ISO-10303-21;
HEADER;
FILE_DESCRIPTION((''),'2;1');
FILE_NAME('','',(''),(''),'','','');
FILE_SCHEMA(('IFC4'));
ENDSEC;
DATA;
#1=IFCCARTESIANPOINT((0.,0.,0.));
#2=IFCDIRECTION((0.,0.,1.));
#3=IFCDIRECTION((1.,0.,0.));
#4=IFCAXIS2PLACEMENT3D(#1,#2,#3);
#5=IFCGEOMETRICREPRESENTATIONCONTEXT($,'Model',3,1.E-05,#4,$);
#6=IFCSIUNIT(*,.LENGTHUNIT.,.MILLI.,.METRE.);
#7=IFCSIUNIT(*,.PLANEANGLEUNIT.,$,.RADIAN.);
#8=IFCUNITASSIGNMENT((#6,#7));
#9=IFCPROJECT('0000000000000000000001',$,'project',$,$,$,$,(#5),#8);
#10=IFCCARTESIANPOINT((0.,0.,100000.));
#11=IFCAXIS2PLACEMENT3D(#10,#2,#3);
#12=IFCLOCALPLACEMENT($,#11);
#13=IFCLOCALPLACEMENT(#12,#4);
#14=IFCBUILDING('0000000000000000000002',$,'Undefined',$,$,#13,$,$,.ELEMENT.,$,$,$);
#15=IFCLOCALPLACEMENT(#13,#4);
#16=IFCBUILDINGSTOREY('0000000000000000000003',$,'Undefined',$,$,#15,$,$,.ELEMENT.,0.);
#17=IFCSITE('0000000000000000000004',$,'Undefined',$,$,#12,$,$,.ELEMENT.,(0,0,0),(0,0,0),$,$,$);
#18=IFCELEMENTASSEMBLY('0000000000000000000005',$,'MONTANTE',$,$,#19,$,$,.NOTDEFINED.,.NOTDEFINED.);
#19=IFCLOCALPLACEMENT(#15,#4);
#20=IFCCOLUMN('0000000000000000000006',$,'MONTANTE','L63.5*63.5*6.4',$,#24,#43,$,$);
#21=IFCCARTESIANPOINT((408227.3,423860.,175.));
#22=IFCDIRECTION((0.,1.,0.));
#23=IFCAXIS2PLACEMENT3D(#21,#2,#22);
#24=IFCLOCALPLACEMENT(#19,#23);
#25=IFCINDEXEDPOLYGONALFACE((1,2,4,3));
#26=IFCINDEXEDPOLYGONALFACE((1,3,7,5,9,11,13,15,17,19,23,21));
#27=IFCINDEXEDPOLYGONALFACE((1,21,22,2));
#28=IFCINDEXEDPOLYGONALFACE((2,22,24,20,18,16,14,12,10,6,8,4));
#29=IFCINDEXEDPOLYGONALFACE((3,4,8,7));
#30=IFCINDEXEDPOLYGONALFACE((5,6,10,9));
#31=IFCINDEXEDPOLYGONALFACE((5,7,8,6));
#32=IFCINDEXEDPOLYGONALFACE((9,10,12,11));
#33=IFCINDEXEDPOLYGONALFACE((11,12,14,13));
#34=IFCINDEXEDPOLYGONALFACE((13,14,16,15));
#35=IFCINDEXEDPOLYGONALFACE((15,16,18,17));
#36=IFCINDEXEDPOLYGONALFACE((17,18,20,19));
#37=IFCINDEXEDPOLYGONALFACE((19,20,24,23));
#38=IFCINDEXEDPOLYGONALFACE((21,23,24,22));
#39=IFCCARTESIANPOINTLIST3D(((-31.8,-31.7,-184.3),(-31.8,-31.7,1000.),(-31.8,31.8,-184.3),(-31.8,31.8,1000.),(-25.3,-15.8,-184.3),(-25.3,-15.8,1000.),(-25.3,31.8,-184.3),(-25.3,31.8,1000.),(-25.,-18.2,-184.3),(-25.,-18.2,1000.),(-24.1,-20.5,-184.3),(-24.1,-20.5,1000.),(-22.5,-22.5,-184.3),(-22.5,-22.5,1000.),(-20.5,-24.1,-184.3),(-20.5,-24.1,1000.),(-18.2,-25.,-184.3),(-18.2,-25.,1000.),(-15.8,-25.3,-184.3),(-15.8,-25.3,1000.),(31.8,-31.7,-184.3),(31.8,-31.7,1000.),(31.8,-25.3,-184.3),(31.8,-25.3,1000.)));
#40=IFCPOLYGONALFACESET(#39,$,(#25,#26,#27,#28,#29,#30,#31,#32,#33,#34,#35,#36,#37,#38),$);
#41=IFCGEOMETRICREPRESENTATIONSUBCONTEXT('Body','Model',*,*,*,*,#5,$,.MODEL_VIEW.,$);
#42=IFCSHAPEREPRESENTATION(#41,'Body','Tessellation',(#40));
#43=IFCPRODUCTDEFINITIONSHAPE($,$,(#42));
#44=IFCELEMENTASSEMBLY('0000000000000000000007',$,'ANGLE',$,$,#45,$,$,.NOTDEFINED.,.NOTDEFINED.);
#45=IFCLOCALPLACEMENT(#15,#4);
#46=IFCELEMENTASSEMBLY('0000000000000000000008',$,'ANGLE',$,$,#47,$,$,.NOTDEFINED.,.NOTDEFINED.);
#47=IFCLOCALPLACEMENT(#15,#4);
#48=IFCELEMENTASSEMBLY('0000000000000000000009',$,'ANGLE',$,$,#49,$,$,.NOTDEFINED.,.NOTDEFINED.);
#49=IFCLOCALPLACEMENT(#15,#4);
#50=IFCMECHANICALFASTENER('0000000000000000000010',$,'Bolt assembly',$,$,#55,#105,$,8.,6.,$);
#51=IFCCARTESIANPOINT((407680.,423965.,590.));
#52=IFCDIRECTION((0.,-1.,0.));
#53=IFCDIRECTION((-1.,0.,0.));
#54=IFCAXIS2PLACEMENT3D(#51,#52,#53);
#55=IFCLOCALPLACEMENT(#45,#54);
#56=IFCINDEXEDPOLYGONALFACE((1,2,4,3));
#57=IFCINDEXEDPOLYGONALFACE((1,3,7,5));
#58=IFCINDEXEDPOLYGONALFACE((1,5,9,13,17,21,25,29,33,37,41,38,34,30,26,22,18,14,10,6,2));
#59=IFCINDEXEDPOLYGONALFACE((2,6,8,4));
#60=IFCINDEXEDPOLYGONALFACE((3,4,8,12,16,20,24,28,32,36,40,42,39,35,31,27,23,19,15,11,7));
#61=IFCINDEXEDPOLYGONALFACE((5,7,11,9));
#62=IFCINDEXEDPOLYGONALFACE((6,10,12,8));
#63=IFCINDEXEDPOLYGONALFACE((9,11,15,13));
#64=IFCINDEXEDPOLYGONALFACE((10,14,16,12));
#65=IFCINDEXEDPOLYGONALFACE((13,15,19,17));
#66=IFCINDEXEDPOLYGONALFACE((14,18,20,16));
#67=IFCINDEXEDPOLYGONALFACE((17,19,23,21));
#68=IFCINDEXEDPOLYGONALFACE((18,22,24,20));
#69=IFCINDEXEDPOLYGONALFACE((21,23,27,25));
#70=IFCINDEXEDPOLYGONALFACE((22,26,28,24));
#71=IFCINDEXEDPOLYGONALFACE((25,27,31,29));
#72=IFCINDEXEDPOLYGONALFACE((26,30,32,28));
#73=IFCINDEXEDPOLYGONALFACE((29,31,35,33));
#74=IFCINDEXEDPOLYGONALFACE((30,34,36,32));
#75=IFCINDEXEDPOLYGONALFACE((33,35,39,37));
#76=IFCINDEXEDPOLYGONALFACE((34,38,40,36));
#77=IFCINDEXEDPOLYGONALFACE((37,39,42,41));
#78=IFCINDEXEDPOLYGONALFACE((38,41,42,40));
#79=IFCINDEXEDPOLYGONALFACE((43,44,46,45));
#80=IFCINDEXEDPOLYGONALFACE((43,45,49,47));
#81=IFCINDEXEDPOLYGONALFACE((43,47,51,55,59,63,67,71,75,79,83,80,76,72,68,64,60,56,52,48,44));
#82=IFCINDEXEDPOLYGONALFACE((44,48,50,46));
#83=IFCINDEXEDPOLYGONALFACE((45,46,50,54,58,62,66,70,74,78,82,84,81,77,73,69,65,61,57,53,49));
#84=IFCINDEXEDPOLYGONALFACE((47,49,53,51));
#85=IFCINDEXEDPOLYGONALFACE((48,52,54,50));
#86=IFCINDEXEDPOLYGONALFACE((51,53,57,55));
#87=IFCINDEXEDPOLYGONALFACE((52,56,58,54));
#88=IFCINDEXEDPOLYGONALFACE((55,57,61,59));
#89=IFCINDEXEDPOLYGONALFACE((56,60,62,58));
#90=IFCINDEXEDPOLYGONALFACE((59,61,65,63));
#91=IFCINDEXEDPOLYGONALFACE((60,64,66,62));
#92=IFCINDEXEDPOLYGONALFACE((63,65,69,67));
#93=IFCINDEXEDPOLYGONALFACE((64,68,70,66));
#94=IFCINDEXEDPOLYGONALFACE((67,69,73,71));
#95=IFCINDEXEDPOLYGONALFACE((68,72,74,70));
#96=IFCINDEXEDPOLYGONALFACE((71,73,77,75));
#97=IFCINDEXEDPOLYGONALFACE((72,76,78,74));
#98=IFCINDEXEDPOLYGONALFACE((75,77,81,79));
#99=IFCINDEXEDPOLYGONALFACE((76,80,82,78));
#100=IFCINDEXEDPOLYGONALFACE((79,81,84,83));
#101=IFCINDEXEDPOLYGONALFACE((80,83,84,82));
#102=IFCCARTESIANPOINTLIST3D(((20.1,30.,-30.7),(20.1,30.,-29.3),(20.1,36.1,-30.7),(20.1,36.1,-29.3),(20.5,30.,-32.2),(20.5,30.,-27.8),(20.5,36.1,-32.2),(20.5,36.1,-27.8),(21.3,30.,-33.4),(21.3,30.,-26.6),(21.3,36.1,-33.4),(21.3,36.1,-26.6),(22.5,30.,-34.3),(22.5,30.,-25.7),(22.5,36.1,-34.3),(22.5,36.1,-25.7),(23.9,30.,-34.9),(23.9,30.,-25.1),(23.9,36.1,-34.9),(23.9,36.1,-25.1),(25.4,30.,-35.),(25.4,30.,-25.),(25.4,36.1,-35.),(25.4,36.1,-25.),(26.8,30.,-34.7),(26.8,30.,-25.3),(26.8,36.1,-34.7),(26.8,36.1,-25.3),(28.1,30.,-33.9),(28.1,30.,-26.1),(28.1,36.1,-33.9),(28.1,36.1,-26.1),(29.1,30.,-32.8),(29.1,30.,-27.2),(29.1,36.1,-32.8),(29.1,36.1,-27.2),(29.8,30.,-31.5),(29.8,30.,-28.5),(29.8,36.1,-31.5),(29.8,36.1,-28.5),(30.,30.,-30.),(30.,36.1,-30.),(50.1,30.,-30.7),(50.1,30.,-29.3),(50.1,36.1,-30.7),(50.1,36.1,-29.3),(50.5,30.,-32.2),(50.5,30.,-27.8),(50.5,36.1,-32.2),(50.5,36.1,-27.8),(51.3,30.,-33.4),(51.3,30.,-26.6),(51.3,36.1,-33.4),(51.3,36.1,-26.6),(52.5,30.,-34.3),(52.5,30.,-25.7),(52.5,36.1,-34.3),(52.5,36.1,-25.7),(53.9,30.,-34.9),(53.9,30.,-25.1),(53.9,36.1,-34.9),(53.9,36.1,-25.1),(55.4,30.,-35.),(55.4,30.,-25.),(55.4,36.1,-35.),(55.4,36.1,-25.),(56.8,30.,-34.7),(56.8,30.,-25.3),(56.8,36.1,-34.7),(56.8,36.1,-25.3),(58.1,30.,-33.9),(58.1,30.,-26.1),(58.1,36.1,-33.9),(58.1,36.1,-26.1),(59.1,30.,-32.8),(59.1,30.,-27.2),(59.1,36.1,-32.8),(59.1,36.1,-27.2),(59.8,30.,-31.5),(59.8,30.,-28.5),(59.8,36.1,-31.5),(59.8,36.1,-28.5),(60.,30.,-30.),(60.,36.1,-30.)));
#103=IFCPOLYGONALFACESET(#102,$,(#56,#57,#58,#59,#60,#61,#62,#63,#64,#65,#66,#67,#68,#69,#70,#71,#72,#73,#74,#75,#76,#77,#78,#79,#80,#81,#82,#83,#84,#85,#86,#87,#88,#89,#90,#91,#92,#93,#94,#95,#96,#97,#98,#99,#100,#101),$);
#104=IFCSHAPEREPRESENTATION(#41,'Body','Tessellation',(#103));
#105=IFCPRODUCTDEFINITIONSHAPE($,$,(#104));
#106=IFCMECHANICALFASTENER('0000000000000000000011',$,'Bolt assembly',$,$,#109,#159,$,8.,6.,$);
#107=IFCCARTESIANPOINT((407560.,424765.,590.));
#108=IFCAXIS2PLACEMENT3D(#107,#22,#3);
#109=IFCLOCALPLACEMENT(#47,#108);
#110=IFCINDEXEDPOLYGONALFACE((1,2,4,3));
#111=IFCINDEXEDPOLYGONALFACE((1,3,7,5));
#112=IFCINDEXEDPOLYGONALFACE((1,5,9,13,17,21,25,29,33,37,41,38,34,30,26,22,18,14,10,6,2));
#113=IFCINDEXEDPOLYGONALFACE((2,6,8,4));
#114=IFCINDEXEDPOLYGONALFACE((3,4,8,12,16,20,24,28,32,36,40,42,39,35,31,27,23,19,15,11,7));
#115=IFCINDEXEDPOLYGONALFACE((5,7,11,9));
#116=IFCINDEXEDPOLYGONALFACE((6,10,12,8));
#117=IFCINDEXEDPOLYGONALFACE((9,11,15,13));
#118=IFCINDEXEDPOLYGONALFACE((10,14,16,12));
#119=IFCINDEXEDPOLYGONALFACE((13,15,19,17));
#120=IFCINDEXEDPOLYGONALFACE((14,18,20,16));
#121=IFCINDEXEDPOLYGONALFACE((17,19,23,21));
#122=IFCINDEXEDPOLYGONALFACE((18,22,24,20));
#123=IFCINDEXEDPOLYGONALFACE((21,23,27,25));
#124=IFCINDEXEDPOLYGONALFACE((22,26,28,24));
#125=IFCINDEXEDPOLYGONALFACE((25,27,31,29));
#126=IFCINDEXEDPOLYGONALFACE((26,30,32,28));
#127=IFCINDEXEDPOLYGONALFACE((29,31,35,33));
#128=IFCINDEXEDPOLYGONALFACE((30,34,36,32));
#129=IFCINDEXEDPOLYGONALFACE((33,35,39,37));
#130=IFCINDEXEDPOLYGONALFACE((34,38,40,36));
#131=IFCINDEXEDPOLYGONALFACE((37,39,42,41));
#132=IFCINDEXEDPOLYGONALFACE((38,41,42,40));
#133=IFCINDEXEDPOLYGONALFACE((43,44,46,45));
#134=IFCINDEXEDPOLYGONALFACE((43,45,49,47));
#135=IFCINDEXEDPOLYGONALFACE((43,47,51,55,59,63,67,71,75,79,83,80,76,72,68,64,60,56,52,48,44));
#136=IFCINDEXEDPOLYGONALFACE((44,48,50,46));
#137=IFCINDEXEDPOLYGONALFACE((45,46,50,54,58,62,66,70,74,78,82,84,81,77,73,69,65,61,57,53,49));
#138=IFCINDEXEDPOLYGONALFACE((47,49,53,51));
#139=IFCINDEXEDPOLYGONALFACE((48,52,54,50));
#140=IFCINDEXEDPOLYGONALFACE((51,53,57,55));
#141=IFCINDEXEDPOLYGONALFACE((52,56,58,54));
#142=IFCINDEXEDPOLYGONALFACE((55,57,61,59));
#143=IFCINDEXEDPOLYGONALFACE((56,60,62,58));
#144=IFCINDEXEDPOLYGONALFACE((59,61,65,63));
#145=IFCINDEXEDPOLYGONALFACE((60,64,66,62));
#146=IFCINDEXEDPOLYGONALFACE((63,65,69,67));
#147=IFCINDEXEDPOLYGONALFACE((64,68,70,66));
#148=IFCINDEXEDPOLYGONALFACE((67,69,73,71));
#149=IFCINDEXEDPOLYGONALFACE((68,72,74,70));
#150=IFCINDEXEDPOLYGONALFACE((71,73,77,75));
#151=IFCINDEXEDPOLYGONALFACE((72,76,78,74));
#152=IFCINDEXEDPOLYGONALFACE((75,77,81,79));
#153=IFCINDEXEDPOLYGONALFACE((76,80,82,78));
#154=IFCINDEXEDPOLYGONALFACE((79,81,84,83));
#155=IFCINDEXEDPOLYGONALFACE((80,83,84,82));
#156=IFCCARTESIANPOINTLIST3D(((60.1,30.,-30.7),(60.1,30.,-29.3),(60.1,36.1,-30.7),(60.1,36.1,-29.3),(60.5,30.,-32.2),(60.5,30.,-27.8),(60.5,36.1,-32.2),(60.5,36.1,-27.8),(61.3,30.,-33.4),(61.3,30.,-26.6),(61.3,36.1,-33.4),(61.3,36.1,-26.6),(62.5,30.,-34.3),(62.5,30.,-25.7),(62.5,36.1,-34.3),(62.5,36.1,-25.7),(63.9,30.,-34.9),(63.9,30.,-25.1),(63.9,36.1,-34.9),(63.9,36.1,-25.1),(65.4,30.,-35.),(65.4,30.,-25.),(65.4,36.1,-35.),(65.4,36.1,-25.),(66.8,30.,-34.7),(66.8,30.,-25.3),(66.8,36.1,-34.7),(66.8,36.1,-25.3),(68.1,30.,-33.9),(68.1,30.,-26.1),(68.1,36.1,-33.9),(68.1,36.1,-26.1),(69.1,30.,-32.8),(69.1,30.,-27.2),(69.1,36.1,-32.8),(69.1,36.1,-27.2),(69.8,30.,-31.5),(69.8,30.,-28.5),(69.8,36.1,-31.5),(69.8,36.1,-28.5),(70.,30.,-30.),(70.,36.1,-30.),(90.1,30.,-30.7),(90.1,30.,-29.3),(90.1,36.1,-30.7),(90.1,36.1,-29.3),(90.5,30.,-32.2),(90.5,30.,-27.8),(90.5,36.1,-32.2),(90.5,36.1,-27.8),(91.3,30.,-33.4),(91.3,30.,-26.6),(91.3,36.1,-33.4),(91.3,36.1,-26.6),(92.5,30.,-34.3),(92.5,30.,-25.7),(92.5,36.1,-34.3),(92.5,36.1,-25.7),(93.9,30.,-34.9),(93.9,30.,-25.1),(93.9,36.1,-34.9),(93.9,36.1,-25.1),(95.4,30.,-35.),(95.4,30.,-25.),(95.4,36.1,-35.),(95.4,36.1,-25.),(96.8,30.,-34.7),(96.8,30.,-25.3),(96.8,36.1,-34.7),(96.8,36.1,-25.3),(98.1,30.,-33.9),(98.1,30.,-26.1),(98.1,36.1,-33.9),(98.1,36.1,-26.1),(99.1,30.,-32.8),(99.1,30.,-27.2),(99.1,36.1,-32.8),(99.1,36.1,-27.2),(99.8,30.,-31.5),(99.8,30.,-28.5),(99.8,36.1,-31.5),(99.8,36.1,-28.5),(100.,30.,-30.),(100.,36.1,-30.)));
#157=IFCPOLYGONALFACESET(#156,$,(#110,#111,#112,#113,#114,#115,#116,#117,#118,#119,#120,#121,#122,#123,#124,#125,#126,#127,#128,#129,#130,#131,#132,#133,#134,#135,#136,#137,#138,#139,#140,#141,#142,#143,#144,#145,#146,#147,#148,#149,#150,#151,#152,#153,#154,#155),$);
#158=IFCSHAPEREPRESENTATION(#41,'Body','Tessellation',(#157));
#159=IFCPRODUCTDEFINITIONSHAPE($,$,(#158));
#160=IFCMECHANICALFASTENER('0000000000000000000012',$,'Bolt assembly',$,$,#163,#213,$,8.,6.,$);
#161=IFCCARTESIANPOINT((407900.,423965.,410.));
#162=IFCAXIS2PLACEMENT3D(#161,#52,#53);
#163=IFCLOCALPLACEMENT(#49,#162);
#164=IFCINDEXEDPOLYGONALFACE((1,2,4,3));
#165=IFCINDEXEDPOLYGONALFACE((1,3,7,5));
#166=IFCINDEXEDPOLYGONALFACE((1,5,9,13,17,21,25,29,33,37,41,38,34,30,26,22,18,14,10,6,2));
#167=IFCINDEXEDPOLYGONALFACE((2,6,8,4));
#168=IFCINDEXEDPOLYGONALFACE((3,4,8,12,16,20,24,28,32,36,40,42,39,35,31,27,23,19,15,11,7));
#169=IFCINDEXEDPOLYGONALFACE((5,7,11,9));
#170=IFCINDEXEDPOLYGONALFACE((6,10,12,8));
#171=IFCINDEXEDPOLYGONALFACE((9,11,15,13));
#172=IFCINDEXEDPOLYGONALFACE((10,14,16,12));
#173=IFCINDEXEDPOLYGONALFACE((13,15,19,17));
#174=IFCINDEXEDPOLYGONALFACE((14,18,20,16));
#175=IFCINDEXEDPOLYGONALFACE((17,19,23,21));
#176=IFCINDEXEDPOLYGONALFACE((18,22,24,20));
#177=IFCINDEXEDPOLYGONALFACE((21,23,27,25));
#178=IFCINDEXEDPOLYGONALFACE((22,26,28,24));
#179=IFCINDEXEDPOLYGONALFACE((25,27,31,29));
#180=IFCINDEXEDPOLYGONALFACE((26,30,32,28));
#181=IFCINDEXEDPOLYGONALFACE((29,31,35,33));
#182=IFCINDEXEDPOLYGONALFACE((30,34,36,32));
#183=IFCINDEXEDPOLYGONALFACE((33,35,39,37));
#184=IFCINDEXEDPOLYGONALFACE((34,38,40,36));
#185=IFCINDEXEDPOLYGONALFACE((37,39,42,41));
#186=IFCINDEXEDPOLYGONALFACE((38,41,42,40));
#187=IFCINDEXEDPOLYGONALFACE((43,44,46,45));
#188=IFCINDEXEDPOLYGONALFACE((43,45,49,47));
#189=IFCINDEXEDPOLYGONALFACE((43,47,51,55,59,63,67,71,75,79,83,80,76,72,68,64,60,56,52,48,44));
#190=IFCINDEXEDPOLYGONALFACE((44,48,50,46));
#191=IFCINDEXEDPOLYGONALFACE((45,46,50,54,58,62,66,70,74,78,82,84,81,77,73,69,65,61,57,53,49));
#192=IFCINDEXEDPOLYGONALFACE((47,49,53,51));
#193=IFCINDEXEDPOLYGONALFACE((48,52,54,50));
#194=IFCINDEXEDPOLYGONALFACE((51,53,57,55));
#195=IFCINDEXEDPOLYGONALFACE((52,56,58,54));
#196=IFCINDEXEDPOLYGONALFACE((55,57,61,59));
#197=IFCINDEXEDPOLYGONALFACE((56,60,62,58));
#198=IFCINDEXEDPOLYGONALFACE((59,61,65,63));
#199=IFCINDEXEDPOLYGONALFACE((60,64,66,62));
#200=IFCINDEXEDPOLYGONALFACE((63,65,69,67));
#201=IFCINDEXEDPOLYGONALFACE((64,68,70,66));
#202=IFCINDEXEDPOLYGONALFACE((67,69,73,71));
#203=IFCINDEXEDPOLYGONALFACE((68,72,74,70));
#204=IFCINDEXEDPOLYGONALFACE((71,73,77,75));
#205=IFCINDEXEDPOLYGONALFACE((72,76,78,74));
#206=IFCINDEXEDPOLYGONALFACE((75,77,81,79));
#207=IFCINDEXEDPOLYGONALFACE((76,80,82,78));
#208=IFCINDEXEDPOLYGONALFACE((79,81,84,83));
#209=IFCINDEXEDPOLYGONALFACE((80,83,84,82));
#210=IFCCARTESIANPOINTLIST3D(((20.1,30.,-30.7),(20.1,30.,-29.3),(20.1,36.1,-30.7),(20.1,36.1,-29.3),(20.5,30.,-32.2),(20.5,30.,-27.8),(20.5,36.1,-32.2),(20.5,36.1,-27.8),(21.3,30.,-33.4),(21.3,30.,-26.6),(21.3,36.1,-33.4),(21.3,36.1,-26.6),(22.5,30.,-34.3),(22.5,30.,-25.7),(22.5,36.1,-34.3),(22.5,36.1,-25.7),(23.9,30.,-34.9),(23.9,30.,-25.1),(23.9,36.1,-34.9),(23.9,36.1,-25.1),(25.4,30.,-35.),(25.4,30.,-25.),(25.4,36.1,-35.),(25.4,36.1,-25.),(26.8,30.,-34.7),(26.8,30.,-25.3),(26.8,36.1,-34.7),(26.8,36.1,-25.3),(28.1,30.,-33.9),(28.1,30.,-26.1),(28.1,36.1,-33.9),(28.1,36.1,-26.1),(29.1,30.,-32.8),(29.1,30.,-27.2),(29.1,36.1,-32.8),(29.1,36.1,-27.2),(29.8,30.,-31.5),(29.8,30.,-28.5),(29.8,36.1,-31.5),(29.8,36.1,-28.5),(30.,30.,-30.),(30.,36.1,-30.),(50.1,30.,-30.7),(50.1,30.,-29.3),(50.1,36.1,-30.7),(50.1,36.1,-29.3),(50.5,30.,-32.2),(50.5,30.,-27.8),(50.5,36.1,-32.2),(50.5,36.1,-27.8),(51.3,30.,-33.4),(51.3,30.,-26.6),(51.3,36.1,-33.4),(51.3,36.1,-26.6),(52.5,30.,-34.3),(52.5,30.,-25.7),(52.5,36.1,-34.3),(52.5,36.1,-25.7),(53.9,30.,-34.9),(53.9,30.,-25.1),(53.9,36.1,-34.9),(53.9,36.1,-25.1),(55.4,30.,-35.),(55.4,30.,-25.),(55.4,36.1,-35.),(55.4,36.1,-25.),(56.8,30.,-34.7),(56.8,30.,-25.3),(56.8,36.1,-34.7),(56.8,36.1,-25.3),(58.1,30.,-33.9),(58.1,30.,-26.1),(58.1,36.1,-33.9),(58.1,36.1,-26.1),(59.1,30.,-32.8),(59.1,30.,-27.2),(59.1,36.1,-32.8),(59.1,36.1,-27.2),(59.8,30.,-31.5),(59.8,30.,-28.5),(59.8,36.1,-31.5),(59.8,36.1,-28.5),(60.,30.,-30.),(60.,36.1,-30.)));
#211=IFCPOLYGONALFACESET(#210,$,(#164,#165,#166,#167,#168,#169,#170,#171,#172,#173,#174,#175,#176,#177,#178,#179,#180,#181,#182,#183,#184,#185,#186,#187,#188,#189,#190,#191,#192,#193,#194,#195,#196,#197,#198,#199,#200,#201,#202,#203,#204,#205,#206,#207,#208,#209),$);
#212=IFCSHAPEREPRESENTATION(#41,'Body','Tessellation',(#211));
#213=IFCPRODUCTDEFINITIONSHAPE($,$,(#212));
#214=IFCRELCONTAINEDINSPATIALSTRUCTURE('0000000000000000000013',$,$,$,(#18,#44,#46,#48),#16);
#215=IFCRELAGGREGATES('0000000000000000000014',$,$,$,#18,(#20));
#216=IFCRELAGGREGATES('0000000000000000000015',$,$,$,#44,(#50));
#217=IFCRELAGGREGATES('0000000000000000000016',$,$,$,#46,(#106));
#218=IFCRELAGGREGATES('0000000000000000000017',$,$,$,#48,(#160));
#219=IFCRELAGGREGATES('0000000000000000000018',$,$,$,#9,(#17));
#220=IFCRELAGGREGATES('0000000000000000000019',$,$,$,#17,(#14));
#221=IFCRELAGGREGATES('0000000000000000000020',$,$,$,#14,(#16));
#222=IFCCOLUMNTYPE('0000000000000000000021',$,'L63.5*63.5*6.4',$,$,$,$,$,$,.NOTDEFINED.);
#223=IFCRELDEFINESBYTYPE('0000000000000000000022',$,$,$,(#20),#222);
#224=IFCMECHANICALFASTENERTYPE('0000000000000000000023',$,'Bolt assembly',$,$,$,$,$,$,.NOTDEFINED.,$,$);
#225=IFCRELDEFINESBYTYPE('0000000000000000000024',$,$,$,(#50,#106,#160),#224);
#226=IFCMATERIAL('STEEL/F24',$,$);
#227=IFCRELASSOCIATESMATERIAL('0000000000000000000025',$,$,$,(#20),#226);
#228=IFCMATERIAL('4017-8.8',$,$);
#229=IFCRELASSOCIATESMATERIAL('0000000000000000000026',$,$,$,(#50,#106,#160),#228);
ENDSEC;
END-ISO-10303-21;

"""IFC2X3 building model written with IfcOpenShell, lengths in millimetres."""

from ifc_helpers import new_model, si_unit, frame, origin_with_axes, origin_2d_with_axis, place, context, subcontext, project, spatial, circle, l_section, extrude, clip, halfspace, source, transform, mapped, material, type_object, element, aggregate, save


model = new_model("IFC2X3")

# Units and contexts
model_context = context("Model", 3, precision=1e-05, world=origin_with_axes())
body_context = subcontext(model_context, "Body", "Model", "MODEL_VIEW")
ifc_project = project(units=[si_unit("LENGTHUNIT", "METRE", prefix="MILLI"), si_unit("PLANEANGLEUNIT", "RADIAN")], contexts=[model_context])

# Site, building, storey
site_placement = place(None, frame((0.0, 0.0, 100000.0), z_axis=(0.0, 0.0, 1.0), x_axis=(1.0, 0.0, 0.0)))
site = spatial("IfcSite", under=ifc_project, at=site_placement, Name="Undefined", CompositionType="ELEMENT", RefLatitude=(0, 0, 0), RefLongitude=(0, 0, 0))
building_placement = place(site_placement, origin_with_axes())
building = spatial("IfcBuilding", under=site, at=building_placement, Name="Undefined", CompositionType="ELEMENT")
storey_placement = place(building_placement, origin_with_axes())
storey = spatial("IfcBuildingStorey", under=building, at=storey_placement, Name="Undefined", CompositionType="ELEMENT", Elevation=0.0)

# Element assembly, column
assembly_1_placement = place(storey_placement, origin_with_axes())
assembly_1 = element("IfcElementAssembly", 1, at=assembly_1_placement, inside=storey, Name="MONTANTE", AssemblyPlace="NOTDEFINED", PredefinedType="NOTDEFINED")
ifc_material_1 = material(Name="STEEL/F24")
column_type = type_object("IfcColumnType", Name="L63.5*63.5*6.4", PredefinedType="NOTDEFINED")
column_placement = place(assembly_1_placement, frame((408227.3, 423860.0, 175.0), z_axis=(0.0, 0.0, 1.0), x_axis=(0.0, 1.0, 0.0)))
column = element("IfcColumn", 2, at=column_placement, type_object=column_type, material=ifc_material_1, Name="MONTANTE", Description="L63.5*63.5*6.4", context=body_context, shape_type="Clipping", body=[
    clip(extrude(l_section(Depth=63.5, Width=63.5, Thickness=6.4, FilletRadius=9.6, at=origin_2d_with_axis()), frame((0.0, 0.0, 1000.0), z_axis=(0.0, 0.0, -1.0), x_axis=(0.0, 1.0, 0.0)), (0.0, 0.0, 1.0), 1184.3), halfspace(frame((0.0, 0.0, -184.3), z_axis=(0.0, 0.0, -1.0), x_axis=(0.0, -1.0, 0.0)), False)),
])

# Element assemblies
assembly_2_placement = place(storey_placement, origin_with_axes())
assembly_2 = element("IfcElementAssembly", 3, at=assembly_2_placement, inside=storey, Name="ANGLE", AssemblyPlace="NOTDEFINED", PredefinedType="NOTDEFINED")
assembly_3_placement = place(storey_placement, origin_with_axes())
assembly_3 = element("IfcElementAssembly", 4, at=assembly_3_placement, inside=storey, Name="ANGLE", AssemblyPlace="NOTDEFINED", PredefinedType="NOTDEFINED")
assembly_4_placement = place(storey_placement, origin_with_axes())
assembly_4 = element("IfcElementAssembly", 5, at=assembly_4_placement, inside=storey, Name="ANGLE", AssemblyPlace="NOTDEFINED", PredefinedType="NOTDEFINED")

# Shared definitions
ifc_material_2 = material(Name="4017-8.8")
mechanical_fastener_type = type_object("IfcMechanicalFastenerType", Name="Bolt assembly")
aggregate(assembly_1, [column])

# Mechanical fasteners
shared_shape_1 = source(origin_with_axes(), body_context, "Body", "SweptSolid", [
    extrude(circle(Radius=5.0, at=origin_2d_with_axis()), frame((0.0, 30.0, 0.0), z_axis=(0.0, 1.0, 0.0), x_axis=(1.0, 0.0, 0.0)), (0.0, 0.0, 1.0), 6.1),
])
mechanical_fastener_1_placement = place(assembly_2_placement, frame((407680.0, 423965.0, 590.0), z_axis=(0.0, -1.0, 0.0), x_axis=(-1.0, 0.0, 0.0)))
mechanical_fastener_1 = element("IfcMechanicalFastener", 6, at=mechanical_fastener_1_placement, type_object=mechanical_fastener_type, material=ifc_material_2, Name="Bolt assembly", NominalDiameter=8.0, NominalLength=6.0, context=body_context, shape_type="MappedRepresentation", body=[
    mapped(shared_shape_1, transform((25.0, 0.0, -30.0))),
    mapped(shared_shape_1, transform((55.0, 0.0, -30.0))),
])
aggregate(assembly_2, [mechanical_fastener_1])
mechanical_fastener_2_placement = place(assembly_3_placement, frame((407560.0, 424765.0, 590.0), z_axis=(0.0, 1.0, 0.0), x_axis=(1.0, 0.0, 0.0)))
mechanical_fastener_2 = element("IfcMechanicalFastener", 7, at=mechanical_fastener_2_placement, type_object=mechanical_fastener_type, material=ifc_material_2, Name="Bolt assembly", NominalDiameter=8.0, NominalLength=6.0, context=body_context, shape_type="MappedRepresentation", body=[
    mapped(shared_shape_1, transform((95.0, 0.0, -30.0))),
    mapped(shared_shape_1, transform((65.0, 0.0, -30.0))),
])
aggregate(assembly_3, [mechanical_fastener_2])
mechanical_fastener_3_placement = place(assembly_4_placement, frame((407900.0, 423965.0, 410.0), z_axis=(0.0, -1.0, 0.0), x_axis=(-1.0, 0.0, 0.0)))
mechanical_fastener_3 = element("IfcMechanicalFastener", 8, at=mechanical_fastener_3_placement, type_object=mechanical_fastener_type, material=ifc_material_2, Name="Bolt assembly", NominalDiameter=8.0, NominalLength=6.0, context=body_context, shape_type="MappedRepresentation", body=[
    mapped(shared_shape_1, transform((25.0, 0.0, -30.0))),
    mapped(shared_shape_1, transform((55.0, 0.0, -30.0))),
])
aggregate(assembly_4, [mechanical_fastener_3])

save(model, "model.ifc")
